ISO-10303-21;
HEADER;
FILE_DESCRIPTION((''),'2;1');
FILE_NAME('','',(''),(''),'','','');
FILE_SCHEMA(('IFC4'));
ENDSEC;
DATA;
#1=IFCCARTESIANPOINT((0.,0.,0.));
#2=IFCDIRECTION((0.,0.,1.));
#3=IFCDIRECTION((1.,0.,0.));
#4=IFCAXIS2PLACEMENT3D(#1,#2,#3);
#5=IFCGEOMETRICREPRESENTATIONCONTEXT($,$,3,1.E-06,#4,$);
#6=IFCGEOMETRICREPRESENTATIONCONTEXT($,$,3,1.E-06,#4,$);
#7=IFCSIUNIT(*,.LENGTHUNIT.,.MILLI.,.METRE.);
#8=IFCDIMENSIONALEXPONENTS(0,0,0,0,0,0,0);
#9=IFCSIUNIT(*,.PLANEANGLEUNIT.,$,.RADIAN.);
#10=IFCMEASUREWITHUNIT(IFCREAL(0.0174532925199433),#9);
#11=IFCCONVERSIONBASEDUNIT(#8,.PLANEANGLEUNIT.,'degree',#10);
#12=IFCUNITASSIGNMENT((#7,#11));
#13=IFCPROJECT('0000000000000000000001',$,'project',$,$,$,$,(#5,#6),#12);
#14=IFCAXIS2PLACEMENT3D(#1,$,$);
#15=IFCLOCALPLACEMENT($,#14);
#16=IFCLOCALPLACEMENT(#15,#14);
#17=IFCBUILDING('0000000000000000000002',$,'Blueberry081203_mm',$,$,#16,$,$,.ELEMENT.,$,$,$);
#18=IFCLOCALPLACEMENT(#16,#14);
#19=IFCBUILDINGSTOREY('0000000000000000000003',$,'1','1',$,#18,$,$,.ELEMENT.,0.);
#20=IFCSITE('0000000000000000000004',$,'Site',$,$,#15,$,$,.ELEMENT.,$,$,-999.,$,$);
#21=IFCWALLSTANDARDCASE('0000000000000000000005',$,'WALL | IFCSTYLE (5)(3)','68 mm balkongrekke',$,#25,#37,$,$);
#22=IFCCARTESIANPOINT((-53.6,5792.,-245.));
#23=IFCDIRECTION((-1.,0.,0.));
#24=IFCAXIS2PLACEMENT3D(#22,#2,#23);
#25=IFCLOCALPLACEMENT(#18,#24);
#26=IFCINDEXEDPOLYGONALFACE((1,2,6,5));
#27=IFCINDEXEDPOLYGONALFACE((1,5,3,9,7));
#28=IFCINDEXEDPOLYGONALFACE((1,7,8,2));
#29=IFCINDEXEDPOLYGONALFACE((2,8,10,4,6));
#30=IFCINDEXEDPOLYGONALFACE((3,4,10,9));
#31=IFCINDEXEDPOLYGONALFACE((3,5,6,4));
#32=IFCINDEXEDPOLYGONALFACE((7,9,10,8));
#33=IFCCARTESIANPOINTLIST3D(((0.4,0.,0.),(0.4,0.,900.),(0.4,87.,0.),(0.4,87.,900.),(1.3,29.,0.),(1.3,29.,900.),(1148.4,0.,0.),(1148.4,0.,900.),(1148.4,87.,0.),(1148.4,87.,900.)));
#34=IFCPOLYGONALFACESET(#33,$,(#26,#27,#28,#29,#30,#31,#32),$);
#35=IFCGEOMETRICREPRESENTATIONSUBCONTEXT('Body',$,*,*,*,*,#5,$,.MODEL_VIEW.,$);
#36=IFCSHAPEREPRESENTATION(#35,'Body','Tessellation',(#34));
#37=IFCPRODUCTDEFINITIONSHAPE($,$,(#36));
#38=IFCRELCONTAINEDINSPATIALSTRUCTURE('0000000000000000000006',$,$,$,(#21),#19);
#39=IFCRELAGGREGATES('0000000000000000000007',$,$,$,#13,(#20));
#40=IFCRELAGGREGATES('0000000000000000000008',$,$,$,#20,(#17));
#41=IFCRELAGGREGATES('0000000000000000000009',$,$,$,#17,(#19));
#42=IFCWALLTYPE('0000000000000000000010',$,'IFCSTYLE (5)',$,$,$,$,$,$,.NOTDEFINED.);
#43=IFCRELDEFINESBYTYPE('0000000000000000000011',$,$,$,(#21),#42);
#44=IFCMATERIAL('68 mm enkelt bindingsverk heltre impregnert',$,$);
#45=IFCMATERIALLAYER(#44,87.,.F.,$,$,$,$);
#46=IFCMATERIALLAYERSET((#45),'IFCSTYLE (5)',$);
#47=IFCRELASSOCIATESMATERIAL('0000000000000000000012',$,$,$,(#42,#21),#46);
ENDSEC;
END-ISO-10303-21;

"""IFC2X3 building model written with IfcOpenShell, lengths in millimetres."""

from ifc_helpers import new_model, entity, si_unit, converted_unit, frame, origin, origin_with_axes, place, context, subcontext, project, spatial, polyline, segment, composite_curve, outline, extrude, material, layer, layer_set, layer_usage, type_object, element, save


model = new_model("IFC2X3")

# Units and contexts
context_of_model_1 = context(None, 3, precision=1e-06, world=origin_with_axes())
context_of_model_2 = context(None, 3, precision=1e-06, world=origin_with_axes())
body_context = subcontext(context_of_model_1, "Body", None, "MODEL_VIEW")
ifc_project = project(units=[si_unit("LENGTHUNIT", "METRE", prefix="MILLI"), converted_unit("PLANEANGLEUNIT", "degree", entity("IfcReal", 0.0174532925199433), si_unit("PLANEANGLEUNIT", "RADIAN"), dimensions=[0, 0, 0, 0, 0, 0, 0])], contexts=[context_of_model_1, context_of_model_2])

# Site, building, storey
site_placement = place(None, origin())
site = spatial("IfcSite", under=ifc_project, at=site_placement, Name="Site", CompositionType="ELEMENT", RefElevation=-999.0)
building_placement = place(site_placement, origin())
building = spatial("IfcBuilding", under=site, at=building_placement, Name="Blueberry081203_mm", CompositionType="ELEMENT")
storey_placement = place(building_placement, origin())
storey = spatial("IfcBuildingStorey", under=building, at=storey_placement, Name="1", Description="1", CompositionType="ELEMENT", Elevation=0.0)

# Wall
ifc_material_1 = material(Name="68 mm enkelt bindingsverk heltre impregnert")
ifc_layer_1 = layer(ifc_material_1, 87.0, ventilated=False)
ifc_layer_set_1 = layer_set([ifc_layer_1], Name="IFCSTYLE (5)")
ifc_layer_usage_1 = layer_usage(ifc_layer_set_1, "AXIS2", "POSITIVE", 0.0)
wall_type_1 = type_object("IfcWallType", Name="IFCSTYLE (5)", PredefinedType="NOTDEFINED", material=ifc_layer_set_1)
wall_1_placement = place(storey_placement, frame((-53.6, 5792.0, -245.0), z_axis=(0.0, 0.0, 1.0), x_axis=(-1.0, 0.0, 0.0)))
element("IfcWallStandardCase", 1, at=wall_1_placement, inside=storey, type_object=wall_type_1, material=ifc_layer_usage_1, Name="WALL | IFCSTYLE (5)(3)", Description="68 mm balkongrekke", context=body_context, shape_type="SweptSolid", held_by="IfcProductRepresentation", body=[
    extrude(outline(composite_curve([segment(polyline([(0.4, 87.0), (1.3, 29.0)]), True, "CONTINUOUS"), segment(polyline([(1.3, 29.0), (0.4, 0.0)]), True, "CONTINUOUS"), segment(polyline([(0.4, 0.0), (1148.4, 0.0)]), True, "CONTINUOUS"), segment(polyline([(1148.4, 0.0), (1148.4, 87.0)]), True, "CONTINUOUS"), segment(polyline([(1148.4, 87.0), (0.4, 87.0)]), True, "CONTINUOUS")], self_intersect=False)), origin(), (0.0, 0.0, 1.0), 900.0),
])

save(model, "model.ifc")
